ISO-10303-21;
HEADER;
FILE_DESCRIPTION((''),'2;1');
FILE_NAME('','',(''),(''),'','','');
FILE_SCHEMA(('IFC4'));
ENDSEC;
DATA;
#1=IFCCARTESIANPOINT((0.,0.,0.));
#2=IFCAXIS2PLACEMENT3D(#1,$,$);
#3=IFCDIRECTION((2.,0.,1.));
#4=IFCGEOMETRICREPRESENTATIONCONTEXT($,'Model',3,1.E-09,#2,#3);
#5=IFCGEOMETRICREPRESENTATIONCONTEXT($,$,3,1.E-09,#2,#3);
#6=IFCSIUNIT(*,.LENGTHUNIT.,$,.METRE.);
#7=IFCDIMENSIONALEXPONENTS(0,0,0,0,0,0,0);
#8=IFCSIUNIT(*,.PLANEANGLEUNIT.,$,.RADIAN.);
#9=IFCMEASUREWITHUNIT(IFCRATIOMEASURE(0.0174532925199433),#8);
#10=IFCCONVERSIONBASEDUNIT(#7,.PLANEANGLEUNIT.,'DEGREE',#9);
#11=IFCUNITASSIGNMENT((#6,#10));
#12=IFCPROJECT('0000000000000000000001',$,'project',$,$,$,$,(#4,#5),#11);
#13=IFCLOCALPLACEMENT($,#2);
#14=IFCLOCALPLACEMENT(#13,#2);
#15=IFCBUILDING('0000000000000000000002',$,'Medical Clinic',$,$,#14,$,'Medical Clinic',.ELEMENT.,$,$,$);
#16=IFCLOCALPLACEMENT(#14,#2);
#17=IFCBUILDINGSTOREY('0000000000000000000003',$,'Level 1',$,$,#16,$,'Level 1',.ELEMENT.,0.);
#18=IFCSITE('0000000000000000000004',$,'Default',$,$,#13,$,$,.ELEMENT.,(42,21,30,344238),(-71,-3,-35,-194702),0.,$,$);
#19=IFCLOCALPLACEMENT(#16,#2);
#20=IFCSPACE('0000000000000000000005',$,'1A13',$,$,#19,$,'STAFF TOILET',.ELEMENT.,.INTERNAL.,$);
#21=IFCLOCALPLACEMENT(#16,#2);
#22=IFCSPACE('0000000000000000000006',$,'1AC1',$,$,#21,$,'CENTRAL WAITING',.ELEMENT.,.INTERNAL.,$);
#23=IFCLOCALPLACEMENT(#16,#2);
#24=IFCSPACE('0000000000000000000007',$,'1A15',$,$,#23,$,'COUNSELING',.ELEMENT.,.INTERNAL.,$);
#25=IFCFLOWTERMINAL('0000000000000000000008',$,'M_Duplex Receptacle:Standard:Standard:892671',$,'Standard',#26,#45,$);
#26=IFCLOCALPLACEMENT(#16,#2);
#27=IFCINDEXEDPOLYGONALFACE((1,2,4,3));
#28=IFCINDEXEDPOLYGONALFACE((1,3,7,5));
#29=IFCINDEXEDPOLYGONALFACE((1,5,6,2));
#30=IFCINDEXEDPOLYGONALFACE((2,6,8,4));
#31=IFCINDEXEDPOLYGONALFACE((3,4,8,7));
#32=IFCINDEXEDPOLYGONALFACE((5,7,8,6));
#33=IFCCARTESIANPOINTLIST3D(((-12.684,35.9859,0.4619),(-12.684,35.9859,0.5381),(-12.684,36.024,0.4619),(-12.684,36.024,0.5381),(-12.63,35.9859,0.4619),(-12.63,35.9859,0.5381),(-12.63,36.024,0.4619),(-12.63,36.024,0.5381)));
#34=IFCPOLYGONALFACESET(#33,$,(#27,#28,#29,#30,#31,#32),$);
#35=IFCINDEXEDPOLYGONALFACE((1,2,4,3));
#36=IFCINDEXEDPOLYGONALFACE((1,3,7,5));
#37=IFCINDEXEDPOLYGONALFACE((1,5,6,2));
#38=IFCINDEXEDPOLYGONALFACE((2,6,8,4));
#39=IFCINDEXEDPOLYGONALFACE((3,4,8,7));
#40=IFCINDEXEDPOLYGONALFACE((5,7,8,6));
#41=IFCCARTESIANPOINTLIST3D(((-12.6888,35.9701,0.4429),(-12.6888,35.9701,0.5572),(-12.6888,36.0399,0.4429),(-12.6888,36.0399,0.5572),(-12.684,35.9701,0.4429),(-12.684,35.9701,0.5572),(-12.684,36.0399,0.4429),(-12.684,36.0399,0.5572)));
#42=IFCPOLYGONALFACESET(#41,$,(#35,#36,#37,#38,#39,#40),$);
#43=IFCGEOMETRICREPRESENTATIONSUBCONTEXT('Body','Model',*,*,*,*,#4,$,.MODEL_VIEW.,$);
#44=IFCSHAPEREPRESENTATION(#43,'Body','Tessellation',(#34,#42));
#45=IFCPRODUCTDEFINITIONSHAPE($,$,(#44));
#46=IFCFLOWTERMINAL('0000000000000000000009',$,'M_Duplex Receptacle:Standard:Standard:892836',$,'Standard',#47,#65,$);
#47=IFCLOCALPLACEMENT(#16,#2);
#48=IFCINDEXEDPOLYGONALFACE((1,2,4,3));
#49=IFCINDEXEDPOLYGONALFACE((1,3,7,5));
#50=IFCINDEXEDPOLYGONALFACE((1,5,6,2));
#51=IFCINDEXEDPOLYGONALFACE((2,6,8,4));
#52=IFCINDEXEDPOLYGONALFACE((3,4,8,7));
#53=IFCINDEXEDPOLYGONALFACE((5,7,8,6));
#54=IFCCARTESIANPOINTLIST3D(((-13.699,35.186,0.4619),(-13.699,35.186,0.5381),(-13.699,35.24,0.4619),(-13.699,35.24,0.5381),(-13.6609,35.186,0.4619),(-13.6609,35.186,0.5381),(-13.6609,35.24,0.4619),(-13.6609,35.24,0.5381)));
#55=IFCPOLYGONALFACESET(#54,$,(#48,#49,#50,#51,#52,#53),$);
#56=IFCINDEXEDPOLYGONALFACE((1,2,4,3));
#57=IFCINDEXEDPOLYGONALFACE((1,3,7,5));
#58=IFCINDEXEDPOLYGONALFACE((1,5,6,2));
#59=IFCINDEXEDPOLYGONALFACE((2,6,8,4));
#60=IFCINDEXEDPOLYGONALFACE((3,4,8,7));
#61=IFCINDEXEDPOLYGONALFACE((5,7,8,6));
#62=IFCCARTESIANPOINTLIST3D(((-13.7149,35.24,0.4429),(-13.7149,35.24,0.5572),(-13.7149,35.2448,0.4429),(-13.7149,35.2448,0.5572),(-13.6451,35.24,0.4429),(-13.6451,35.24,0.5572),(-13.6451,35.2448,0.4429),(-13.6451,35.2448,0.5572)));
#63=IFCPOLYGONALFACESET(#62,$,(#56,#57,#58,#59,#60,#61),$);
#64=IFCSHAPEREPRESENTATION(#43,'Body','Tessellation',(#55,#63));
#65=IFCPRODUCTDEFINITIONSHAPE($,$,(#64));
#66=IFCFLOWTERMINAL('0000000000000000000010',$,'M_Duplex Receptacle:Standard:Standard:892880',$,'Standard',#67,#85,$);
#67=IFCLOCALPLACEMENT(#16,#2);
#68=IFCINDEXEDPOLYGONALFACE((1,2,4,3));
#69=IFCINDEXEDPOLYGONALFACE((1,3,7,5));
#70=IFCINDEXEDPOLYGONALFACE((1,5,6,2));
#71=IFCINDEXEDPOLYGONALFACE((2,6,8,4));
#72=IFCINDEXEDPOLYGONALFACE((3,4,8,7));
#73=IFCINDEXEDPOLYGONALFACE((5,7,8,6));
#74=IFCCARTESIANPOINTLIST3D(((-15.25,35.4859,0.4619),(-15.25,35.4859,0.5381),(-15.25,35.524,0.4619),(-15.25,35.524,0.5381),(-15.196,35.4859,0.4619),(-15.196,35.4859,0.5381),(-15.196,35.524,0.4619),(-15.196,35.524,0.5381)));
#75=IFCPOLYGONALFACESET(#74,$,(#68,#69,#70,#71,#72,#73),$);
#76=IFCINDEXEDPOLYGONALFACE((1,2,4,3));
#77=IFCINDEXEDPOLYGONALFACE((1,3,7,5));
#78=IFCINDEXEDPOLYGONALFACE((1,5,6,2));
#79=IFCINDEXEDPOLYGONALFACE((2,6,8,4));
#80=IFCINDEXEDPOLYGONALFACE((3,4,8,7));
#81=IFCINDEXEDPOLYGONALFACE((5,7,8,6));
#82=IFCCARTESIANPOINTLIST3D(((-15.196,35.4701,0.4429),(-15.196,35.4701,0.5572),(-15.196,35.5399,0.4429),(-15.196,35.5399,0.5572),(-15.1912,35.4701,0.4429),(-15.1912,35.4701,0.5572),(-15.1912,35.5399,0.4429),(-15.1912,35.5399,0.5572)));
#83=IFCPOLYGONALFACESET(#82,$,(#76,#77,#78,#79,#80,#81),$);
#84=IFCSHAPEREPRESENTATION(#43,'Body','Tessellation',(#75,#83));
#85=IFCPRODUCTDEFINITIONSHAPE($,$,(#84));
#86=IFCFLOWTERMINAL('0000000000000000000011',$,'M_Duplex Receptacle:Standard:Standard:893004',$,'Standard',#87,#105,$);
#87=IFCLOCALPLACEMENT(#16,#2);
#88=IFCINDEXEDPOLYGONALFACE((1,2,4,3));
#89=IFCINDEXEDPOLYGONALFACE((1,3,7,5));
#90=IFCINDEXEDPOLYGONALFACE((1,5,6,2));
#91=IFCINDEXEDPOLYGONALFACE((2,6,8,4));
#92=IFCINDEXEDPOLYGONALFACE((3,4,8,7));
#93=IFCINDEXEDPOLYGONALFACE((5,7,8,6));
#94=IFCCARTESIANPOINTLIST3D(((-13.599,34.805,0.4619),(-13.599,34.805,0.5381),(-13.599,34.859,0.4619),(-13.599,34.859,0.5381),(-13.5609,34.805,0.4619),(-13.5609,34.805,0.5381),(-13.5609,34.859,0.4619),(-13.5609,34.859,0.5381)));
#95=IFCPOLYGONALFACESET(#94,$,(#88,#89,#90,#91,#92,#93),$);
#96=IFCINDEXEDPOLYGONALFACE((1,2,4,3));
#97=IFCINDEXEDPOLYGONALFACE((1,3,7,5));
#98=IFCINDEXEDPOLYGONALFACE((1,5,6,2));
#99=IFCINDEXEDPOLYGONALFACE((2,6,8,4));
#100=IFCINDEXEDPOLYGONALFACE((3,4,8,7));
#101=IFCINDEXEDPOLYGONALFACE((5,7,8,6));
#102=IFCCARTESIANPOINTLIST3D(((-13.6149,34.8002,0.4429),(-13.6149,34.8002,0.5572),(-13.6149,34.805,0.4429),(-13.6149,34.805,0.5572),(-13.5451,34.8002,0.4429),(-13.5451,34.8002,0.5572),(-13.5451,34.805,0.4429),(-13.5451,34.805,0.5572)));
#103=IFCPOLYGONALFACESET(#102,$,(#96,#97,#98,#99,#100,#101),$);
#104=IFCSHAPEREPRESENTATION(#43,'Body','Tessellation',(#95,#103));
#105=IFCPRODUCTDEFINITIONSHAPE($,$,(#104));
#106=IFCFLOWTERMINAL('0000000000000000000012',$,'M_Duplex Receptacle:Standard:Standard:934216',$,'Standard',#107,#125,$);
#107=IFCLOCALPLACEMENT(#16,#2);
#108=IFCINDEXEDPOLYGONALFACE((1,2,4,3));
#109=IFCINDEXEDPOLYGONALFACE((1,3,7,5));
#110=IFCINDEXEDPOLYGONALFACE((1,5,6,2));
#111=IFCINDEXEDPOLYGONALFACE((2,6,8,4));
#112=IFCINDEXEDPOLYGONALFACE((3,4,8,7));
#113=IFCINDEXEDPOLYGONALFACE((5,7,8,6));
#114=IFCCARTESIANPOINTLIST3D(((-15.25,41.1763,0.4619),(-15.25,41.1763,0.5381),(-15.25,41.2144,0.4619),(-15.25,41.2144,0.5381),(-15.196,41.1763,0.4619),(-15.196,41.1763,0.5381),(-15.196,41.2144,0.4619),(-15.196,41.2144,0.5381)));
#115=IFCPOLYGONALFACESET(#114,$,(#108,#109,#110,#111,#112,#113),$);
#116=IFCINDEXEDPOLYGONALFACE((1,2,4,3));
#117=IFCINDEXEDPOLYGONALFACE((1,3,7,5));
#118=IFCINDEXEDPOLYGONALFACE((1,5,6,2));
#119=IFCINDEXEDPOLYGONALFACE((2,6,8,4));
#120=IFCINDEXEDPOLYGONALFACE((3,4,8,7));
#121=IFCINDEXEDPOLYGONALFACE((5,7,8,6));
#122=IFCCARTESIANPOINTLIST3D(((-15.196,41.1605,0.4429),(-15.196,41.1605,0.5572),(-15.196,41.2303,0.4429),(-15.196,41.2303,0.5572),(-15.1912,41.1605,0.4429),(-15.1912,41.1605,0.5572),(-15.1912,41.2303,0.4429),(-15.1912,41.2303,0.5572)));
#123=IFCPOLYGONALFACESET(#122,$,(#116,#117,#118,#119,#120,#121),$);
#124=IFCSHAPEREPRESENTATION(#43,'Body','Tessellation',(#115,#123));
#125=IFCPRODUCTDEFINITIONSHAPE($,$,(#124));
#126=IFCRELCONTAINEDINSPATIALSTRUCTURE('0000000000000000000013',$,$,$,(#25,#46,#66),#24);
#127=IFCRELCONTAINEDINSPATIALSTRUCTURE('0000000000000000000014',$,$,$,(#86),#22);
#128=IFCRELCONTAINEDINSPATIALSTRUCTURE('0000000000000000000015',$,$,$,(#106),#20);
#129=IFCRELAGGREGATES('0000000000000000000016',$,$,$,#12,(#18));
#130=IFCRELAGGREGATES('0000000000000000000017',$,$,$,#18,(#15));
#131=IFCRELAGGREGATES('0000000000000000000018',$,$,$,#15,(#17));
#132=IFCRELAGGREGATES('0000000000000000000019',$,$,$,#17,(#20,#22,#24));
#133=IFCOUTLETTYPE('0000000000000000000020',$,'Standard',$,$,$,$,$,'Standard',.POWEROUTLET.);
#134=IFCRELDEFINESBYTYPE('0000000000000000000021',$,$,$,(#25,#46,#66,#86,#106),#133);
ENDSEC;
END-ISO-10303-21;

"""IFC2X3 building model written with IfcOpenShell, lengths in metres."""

from ifc_helpers import new_model, entity, si_unit, converted_unit, direction, frame, frame_2d, origin, origin_2d_with_axis, place, context, subcontext, project, spatial, rectangle, extrude, source, transform, mapped, type_object, type_shapes, element, save


model = new_model("IFC2X3")

# Units and contexts
model_context = context("Model", 3, precision=1e-09, world=origin(), true_north=direction((2.0, 0.0, 1.0)))
context_of_model = context(None, 3, precision=1e-09, world=origin(), true_north=direction((2.0, 0.0, 1.0)))
body_context = subcontext(model_context, "Body", "Model", "MODEL_VIEW")
ifc_project = project(units=[si_unit("LENGTHUNIT", "METRE"), converted_unit("PLANEANGLEUNIT", "DEGREE", entity("IfcRatioMeasure", 0.0174532925199433), si_unit("PLANEANGLEUNIT", "RADIAN"), dimensions=[0, 0, 0, 0, 0, 0, 0])], contexts=[model_context, context_of_model])

# Site, building, storey, space
site_placement = place(None, origin())
site = spatial("IfcSite", under=ifc_project, at=site_placement, Name="Default", CompositionType="ELEMENT", RefLatitude=(42, 21, 30, 344238), RefLongitude=(-71, -3, -35, -194702), RefElevation=0.0)
building_placement = place(site_placement, origin())
building = spatial("IfcBuilding", under=site, at=building_placement, Name="Medical Clinic", LongName="Medical Clinic", CompositionType="ELEMENT")
storey_placement = place(building_placement, origin())
storey = spatial("IfcBuildingStorey", under=building, at=storey_placement, Name="Level 1", LongName="Level 1", CompositionType="ELEMENT", Elevation=0.0)
space_1_placement = place(storey_placement, origin())
space_1 = spatial("IfcSpace", under=storey, at=space_1_placement, Name="1A13", LongName="STAFF TOILET", CompositionType="ELEMENT", InteriorOrExteriorSpace="INTERNAL")

# Shared definitions
space_2_placement = place(storey_placement, origin())
space_2 = spatial("IfcSpace", under=storey, at=space_2_placement, Name="1AC1", LongName="CENTRAL WAITING", CompositionType="ELEMENT", InteriorOrExteriorSpace="INTERNAL")

# Shared definitions
space_3_placement = place(storey_placement, origin())
space_3 = spatial("IfcSpace", under=storey, at=space_3_placement, Name="1A15", LongName="COUNSELING", CompositionType="ELEMENT", InteriorOrExteriorSpace="INTERNAL")

# Shared definitions
outlet_type = type_object("IfcOutletType", Name="Standard", ElementType="Standard", PredefinedType="POWEROUTLET")
shared_shape_1 = source(origin(), body_context, "Body", "SweptSolid", [
    extrude(rectangle(XDim=0.0381, YDim=0.0762, at=origin_2d_with_axis()), frame((0.0, 0.0, -0.054), z_axis=(0.0, 0.0, 1.0), x_axis=(-1.0, 0.0, 0.0)), (0.0, 0.0, 1.0), 0.054),
    extrude(rectangle(XDim=0.0698, YDim=0.1143, at=frame_2d((0.0, 0.0), x_axis=(1.0, 0.0))), frame((0.0, 0.0, 0.0), z_axis=(0.0, 0.0, 1.0), x_axis=(-1.0, 0.0, 0.0)), (0.0, 0.0, 1.0), 0.0048),
])
type_shapes(outlet_type, [shared_shape_1])

# Flow terminals
for number, where, z_axis, x_axis, name in (
    (1, (-12.684, 36.005, 0.5), (-1.0, 0.0, 0.0), (0.0, -1.0, 0.0), "M_Duplex Receptacle:Standard:Standard:892671"),
    (2, (-13.68, 35.24, 0.5), (0.0, 1.0, 0.0), (-1.0, 0.0, 0.0), "M_Duplex Receptacle:Standard:Standard:892836"),
    (3, (-15.196, 35.505, 0.5), (1.0, 0.0, 0.0), (0.0, 1.0, 0.0), "M_Duplex Receptacle:Standard:Standard:892880"),
):
    element("IfcFlowTerminal", number, at=place(space_3_placement, frame(where, z_axis=z_axis, x_axis=x_axis)), inside=space_3, type_object=outlet_type, Name=name, ObjectType="Standard", context=body_context, shape_type="MappedRepresentation", body=[
        mapped(shared_shape_1, transform((0.0, 0.0, 0.0), scale=1.0)),
    ])
flow_terminal_1_placement = place(space_2_placement, frame((-13.58, 34.805, 0.5), z_axis=(0.0, -1.0, 0.0), x_axis=(1.0, 0.0, 0.0)))
element("IfcFlowTerminal", 4, at=flow_terminal_1_placement, inside=space_2, type_object=outlet_type, Name="M_Duplex Receptacle:Standard:Standard:893004", ObjectType="Standard", context=body_context, shape_type="MappedRepresentation", body=[
    mapped(shared_shape_1, transform((0.0, 0.0, 0.0), scale=1.0)),
])
flow_terminal_2_placement = place(space_1_placement, frame((-15.196, 41.1954, 0.5), z_axis=(1.0, 0.0, 0.0), x_axis=(0.0, 1.0, 0.0)))
element("IfcFlowTerminal", 5, at=flow_terminal_2_placement, inside=space_1, type_object=outlet_type, Name="M_Duplex Receptacle:Standard:Standard:934216", ObjectType="Standard", context=body_context, shape_type="MappedRepresentation", body=[
    mapped(shared_shape_1, transform((0.0, 0.0, 0.0), scale=1.0)),
])

save(model, "model.ifc")
